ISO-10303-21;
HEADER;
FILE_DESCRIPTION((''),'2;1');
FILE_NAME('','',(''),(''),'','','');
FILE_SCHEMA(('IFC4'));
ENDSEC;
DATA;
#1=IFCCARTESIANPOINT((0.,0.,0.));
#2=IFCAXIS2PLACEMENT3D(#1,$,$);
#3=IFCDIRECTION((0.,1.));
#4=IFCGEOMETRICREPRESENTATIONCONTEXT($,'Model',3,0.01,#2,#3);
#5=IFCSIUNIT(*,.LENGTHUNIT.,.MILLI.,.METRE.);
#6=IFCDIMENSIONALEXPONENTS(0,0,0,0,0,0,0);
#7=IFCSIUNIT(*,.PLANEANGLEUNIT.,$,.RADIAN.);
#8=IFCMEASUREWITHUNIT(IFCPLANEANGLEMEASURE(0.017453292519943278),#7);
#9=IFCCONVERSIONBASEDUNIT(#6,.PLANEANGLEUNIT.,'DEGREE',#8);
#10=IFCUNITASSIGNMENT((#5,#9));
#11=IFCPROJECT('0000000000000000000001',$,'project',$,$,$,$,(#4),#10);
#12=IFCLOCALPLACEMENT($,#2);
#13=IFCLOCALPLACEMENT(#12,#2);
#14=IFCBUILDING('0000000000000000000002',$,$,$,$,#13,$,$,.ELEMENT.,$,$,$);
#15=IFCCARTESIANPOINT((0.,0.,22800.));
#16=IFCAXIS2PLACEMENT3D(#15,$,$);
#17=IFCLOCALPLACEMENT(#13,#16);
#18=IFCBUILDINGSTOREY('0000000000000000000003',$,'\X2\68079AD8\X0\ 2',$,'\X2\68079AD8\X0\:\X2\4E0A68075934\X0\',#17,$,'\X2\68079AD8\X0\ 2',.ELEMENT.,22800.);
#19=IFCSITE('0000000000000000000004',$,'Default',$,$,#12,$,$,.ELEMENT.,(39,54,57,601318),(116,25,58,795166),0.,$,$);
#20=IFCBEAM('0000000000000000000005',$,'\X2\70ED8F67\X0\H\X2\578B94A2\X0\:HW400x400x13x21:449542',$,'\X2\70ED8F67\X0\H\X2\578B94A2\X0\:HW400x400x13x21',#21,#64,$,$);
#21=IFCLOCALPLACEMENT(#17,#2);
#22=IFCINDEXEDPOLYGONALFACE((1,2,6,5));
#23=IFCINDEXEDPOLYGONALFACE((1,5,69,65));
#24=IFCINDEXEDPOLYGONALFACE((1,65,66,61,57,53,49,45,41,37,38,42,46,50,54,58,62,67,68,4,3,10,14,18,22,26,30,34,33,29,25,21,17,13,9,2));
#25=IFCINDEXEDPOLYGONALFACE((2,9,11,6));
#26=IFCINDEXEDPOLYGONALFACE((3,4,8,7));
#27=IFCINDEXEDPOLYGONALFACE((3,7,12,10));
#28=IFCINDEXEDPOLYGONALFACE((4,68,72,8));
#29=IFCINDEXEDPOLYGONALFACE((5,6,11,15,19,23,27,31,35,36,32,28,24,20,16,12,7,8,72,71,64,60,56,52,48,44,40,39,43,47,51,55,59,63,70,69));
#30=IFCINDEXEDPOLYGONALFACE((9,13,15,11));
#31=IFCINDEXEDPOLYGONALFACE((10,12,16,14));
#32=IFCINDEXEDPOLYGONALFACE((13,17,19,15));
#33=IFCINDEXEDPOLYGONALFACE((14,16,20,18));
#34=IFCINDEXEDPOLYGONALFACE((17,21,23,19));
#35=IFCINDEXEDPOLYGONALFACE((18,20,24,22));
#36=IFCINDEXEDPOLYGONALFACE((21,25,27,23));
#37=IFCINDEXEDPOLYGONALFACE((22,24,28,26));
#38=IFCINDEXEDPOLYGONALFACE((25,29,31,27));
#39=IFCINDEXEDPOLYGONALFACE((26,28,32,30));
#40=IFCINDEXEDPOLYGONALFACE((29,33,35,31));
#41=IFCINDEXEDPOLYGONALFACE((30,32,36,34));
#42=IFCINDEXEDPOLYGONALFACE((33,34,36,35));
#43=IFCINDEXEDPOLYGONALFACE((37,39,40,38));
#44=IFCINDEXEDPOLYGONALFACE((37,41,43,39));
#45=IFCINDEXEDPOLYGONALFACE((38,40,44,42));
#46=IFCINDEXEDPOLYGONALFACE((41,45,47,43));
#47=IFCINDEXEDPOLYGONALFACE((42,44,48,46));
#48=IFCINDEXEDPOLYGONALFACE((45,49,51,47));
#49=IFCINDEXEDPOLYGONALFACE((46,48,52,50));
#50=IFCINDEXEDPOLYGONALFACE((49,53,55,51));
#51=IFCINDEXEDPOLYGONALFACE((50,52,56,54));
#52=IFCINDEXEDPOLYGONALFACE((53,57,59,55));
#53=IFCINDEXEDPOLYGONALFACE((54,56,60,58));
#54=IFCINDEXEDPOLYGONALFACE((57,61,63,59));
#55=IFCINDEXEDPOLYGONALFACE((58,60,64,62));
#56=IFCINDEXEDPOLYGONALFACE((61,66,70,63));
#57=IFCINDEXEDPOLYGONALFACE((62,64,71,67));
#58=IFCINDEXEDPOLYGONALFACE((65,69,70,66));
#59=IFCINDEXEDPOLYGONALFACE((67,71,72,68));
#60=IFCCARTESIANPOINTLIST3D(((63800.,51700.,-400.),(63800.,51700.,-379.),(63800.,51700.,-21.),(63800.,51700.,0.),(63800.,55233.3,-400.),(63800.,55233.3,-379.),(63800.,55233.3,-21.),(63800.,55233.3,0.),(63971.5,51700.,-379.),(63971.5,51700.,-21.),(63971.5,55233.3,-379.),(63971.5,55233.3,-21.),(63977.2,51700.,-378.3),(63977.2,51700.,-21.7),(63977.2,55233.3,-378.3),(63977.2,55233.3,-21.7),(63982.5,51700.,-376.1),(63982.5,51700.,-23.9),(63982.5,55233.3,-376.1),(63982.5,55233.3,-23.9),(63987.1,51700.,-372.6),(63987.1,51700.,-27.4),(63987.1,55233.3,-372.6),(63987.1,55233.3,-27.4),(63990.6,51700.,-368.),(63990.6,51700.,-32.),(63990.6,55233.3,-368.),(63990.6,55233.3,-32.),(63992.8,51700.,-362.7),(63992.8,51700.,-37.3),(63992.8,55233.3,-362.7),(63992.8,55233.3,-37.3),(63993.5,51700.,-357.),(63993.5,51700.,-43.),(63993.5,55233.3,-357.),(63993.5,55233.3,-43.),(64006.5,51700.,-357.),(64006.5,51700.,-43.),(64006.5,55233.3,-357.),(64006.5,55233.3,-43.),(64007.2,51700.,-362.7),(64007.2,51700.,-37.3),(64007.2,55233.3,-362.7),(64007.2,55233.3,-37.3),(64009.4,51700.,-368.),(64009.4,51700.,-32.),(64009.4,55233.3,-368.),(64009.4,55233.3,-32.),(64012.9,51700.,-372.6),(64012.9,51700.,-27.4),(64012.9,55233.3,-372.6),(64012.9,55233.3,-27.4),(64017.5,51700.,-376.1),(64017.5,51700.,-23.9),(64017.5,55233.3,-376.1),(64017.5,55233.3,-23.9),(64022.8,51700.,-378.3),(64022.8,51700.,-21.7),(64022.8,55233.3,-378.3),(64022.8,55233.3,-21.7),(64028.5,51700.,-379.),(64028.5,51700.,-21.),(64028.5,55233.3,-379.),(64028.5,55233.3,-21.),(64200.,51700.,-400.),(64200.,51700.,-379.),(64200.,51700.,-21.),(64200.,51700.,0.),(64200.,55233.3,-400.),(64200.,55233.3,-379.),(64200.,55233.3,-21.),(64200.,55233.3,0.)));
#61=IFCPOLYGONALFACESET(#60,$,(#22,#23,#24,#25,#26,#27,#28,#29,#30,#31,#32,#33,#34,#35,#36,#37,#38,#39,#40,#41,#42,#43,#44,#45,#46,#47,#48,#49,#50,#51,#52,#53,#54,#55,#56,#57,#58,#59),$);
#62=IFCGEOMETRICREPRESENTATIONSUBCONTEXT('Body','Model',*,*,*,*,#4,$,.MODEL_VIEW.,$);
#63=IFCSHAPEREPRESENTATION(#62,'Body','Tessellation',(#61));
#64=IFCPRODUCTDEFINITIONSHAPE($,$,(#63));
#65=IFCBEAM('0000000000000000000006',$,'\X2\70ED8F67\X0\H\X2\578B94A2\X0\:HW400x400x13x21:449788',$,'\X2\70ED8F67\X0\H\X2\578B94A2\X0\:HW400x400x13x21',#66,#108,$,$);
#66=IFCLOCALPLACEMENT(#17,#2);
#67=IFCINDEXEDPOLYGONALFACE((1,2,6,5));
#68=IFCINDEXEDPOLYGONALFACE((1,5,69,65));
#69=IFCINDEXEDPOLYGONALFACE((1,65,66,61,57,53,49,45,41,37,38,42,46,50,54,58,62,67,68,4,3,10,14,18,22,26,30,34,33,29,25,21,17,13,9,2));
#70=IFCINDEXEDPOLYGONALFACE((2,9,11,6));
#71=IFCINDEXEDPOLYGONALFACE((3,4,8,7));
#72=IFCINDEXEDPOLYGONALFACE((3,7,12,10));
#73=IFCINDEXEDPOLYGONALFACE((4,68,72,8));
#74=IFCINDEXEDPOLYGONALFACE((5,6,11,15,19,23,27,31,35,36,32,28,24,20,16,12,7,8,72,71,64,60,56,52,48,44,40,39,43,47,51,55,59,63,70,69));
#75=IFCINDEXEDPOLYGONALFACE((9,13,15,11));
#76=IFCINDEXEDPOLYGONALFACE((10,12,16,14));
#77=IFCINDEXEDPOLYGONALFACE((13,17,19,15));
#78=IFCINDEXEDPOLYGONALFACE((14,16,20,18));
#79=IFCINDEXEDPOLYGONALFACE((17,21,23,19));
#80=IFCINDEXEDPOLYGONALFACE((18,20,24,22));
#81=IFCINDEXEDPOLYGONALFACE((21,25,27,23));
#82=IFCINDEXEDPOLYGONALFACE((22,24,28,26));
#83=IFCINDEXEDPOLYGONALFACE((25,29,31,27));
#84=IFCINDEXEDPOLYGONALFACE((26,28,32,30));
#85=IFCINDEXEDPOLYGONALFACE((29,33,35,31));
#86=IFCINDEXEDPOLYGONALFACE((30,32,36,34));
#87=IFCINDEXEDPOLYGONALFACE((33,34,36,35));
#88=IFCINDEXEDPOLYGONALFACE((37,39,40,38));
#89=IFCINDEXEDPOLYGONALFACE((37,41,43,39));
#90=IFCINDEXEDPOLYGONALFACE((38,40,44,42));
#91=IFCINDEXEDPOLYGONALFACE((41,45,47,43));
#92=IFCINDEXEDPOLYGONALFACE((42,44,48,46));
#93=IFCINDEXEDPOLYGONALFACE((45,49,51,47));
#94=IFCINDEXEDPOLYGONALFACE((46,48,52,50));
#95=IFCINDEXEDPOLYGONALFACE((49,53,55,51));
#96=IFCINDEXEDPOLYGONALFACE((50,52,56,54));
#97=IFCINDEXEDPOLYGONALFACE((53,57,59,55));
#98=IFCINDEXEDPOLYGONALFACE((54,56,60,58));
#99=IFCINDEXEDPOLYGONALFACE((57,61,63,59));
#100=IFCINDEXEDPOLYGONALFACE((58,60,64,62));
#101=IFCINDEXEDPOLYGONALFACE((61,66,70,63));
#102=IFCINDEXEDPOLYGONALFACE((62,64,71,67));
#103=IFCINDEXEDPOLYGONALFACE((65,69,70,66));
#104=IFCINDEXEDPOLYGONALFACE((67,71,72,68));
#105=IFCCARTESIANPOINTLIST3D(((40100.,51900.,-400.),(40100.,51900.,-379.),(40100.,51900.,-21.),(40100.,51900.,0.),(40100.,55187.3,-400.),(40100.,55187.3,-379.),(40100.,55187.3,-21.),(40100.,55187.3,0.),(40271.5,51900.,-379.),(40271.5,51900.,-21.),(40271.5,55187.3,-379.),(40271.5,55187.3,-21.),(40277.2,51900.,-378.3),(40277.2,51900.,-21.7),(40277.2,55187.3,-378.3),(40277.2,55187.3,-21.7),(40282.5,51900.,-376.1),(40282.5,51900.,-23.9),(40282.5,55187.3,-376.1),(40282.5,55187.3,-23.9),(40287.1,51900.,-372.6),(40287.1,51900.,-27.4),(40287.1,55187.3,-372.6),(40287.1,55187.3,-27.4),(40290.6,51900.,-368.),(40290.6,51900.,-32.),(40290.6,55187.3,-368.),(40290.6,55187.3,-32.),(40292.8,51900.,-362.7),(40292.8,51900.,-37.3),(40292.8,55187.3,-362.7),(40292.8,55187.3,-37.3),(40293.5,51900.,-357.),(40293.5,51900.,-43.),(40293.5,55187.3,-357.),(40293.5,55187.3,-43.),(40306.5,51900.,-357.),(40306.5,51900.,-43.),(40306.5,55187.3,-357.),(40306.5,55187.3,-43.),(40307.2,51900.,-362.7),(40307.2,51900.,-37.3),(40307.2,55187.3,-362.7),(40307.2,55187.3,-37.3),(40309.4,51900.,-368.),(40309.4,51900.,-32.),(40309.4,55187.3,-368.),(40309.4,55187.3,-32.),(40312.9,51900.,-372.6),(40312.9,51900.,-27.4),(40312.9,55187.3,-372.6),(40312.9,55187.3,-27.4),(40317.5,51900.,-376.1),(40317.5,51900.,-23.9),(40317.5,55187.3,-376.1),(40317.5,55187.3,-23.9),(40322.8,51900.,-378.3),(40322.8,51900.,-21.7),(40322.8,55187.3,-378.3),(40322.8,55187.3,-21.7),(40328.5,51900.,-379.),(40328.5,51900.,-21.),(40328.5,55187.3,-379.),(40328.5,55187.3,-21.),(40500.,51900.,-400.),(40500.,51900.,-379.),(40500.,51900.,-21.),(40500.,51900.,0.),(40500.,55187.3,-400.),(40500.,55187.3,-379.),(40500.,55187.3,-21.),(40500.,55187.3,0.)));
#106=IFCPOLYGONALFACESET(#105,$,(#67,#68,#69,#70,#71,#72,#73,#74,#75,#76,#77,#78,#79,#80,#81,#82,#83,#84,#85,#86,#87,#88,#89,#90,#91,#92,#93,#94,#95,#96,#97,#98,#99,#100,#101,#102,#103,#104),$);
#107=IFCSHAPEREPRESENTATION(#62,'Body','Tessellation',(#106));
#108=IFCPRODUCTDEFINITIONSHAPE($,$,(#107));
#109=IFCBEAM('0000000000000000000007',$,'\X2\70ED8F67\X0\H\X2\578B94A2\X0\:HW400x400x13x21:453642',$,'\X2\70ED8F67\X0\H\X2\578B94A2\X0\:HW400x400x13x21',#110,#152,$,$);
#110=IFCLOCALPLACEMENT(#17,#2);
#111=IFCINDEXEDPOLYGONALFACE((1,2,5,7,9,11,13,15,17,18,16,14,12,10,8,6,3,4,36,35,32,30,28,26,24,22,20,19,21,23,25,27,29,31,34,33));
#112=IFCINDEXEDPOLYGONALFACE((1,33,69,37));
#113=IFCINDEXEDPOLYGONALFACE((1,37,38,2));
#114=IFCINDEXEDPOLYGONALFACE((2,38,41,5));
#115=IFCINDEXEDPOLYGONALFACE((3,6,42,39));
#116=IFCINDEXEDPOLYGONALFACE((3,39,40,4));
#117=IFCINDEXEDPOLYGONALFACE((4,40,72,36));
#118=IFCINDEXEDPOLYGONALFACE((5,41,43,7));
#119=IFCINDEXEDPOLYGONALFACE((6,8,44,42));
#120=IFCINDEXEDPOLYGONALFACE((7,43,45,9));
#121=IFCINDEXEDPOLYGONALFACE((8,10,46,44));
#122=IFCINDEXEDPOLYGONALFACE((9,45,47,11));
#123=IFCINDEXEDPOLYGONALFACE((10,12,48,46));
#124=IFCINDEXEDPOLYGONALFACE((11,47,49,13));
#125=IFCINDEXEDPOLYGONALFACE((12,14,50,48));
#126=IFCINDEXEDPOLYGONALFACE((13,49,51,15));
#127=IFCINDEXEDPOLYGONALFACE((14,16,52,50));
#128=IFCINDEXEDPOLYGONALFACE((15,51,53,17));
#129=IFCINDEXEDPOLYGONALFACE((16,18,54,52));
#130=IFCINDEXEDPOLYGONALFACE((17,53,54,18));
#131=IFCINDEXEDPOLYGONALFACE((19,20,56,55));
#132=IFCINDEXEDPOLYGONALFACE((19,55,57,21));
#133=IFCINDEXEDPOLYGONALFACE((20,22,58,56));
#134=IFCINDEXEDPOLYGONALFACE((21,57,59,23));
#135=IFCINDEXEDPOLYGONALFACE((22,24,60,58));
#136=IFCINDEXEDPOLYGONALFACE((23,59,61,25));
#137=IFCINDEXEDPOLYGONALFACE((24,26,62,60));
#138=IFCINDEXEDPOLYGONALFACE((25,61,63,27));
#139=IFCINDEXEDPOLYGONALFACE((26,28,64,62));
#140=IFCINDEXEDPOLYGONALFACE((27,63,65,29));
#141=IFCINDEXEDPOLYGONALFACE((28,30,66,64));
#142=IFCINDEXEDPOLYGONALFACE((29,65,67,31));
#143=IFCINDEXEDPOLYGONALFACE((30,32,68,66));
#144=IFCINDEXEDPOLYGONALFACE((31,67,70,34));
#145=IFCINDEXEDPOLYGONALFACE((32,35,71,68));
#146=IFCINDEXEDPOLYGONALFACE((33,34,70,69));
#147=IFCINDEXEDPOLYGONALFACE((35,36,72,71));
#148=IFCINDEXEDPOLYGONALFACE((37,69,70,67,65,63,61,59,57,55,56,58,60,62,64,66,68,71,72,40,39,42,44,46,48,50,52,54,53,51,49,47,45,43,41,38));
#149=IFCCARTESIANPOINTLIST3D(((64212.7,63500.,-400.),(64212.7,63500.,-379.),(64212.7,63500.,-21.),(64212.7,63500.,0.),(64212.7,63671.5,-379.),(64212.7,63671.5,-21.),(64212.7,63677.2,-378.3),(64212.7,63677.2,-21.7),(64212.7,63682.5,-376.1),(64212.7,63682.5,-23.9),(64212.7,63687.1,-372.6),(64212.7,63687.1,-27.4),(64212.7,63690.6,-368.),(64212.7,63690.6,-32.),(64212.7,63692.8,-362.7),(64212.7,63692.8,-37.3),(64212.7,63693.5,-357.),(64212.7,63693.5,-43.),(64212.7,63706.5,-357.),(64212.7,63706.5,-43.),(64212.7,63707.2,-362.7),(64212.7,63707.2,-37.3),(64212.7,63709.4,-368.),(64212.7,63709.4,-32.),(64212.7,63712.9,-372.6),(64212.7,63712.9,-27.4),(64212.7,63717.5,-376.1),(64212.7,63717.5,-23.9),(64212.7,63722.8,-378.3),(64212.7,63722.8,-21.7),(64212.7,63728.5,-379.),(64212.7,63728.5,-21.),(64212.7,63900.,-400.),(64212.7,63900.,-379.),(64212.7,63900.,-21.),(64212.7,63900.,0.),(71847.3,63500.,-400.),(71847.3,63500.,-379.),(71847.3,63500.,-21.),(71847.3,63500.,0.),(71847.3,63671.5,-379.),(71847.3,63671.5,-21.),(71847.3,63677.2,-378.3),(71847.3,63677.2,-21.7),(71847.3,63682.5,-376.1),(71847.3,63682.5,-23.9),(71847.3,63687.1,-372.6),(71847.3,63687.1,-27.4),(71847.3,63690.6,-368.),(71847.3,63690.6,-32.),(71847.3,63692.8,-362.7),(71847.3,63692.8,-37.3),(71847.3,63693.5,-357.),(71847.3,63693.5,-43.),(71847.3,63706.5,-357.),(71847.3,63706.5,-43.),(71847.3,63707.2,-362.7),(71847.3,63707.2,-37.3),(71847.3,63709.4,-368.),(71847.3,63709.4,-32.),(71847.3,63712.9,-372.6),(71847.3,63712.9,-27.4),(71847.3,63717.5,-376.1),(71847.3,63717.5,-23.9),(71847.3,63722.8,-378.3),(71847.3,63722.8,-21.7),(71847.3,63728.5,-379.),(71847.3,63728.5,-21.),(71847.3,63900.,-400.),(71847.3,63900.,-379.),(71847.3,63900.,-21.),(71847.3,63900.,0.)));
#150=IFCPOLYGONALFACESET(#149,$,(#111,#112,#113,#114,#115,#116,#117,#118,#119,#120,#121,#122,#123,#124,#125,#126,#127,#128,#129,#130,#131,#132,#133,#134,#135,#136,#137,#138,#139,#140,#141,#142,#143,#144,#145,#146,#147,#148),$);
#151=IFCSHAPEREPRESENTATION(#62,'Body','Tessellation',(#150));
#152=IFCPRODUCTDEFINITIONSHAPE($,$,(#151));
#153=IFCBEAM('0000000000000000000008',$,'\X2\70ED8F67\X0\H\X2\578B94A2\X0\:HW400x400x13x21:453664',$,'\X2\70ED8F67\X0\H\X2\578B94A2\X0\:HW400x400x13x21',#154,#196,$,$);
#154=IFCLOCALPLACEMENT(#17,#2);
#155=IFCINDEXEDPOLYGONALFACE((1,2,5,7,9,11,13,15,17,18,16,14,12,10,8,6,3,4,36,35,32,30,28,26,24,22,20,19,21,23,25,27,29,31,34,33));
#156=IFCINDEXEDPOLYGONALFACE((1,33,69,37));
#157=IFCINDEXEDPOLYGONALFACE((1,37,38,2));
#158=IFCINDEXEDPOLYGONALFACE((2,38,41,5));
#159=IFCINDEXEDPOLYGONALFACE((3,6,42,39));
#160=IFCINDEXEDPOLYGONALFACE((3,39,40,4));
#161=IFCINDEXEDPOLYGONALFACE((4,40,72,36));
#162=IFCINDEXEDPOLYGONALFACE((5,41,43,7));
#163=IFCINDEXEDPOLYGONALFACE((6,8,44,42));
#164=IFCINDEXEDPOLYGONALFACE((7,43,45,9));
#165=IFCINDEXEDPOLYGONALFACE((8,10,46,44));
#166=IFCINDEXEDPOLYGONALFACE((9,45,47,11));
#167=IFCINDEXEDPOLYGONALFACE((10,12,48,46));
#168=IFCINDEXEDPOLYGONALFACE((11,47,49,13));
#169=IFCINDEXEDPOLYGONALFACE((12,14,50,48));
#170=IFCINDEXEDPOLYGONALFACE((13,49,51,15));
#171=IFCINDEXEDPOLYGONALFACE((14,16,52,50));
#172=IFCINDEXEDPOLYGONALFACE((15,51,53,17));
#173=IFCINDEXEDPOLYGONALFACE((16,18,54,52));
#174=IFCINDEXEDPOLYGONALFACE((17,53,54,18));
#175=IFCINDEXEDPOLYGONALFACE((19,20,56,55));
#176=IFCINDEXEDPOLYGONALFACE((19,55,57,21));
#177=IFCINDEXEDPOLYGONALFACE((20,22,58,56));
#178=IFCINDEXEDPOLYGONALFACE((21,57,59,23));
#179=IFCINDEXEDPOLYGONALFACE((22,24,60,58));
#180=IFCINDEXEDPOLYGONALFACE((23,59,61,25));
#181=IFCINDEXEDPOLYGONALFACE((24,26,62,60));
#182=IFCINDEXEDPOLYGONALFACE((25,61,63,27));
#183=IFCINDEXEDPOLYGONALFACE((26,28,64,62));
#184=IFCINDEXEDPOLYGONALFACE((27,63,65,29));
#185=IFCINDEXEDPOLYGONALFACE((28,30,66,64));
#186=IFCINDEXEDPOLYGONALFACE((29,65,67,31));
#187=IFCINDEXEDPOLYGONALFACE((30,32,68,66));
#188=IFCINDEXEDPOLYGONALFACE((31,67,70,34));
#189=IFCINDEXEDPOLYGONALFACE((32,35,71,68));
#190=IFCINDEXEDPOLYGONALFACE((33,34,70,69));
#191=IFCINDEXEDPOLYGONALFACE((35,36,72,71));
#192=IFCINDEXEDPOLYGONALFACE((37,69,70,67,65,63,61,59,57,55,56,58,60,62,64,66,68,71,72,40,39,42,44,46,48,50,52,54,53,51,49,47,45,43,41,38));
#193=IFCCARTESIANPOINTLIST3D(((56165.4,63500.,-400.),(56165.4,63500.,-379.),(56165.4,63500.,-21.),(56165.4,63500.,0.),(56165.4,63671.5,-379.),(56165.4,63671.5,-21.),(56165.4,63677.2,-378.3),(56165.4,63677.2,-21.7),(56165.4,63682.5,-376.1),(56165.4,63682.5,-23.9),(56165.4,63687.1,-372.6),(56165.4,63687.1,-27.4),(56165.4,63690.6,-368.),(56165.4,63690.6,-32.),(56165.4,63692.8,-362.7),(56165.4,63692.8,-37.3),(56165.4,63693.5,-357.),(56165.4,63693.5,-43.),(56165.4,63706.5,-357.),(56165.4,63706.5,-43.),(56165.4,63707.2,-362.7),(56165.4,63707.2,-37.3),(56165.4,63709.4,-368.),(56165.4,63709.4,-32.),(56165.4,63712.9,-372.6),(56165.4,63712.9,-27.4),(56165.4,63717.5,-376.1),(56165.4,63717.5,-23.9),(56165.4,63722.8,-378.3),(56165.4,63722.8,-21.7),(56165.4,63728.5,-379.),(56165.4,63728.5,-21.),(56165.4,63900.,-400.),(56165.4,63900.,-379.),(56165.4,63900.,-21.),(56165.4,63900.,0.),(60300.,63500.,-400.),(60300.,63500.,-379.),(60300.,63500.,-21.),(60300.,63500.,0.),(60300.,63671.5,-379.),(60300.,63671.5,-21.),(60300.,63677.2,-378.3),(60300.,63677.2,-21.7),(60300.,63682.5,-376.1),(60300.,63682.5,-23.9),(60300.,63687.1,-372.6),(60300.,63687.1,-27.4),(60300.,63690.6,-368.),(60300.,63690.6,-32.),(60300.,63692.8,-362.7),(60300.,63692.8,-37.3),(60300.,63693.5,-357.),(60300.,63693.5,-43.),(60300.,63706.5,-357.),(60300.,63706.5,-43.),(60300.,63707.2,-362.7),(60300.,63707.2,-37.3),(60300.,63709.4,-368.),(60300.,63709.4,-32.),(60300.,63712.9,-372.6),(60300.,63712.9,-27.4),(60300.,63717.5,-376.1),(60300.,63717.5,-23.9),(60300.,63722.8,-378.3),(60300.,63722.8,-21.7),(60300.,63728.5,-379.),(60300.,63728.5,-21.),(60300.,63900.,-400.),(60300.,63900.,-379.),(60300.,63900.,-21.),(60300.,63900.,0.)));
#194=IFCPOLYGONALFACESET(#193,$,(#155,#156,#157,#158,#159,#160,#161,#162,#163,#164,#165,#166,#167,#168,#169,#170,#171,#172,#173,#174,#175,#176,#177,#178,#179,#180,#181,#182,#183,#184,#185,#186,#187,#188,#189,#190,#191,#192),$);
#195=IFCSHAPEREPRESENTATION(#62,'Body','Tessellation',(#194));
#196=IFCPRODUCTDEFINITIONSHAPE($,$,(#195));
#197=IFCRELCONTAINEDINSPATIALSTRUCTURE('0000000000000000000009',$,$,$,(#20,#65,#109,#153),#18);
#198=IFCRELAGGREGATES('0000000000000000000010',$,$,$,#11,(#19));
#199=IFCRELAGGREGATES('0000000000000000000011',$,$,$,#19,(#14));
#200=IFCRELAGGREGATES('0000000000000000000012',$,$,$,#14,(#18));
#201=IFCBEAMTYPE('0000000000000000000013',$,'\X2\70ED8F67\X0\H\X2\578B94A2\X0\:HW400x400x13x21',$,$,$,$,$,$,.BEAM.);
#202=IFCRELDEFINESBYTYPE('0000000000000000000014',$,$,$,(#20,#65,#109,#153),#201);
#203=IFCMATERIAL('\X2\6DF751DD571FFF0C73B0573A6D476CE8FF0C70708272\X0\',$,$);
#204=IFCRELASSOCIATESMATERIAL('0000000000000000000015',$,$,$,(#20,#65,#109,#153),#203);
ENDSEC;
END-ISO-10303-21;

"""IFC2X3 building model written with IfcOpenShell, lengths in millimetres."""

from ifc_helpers import new_model, entity, si_unit, converted_unit, direction, frame, frame_2d, origin, place, context, subcontext, project, spatial, i_section, extrude, material, type_object, element, save


model = new_model("IFC2X3")

# Units and contexts
model_context = context("Model", 3, precision=0.01, world=origin(), true_north=direction((0.0, 1.0)))
body_context = subcontext(model_context, "Body", "Model", "MODEL_VIEW")
ifc_project = project(units=[si_unit("LENGTHUNIT", "METRE", prefix="MILLI"), converted_unit("PLANEANGLEUNIT", "DEGREE", entity("IfcPlaneAngleMeasure", 0.017453292519943278), si_unit("PLANEANGLEUNIT", "RADIAN"), dimensions=[0, 0, 0, 0, 0, 0, 0])], contexts=[model_context])

# Site, building, storey
site_placement = place(None, origin())
site = spatial("IfcSite", under=ifc_project, at=site_placement, Name="Default", CompositionType="ELEMENT", RefLatitude=(39, 54, 57, 601318), RefLongitude=(116, 25, 58, 795166), RefElevation=0.0)
building_placement = place(site_placement, origin())
building = spatial("IfcBuilding", under=site, at=building_placement, CompositionType="ELEMENT")
storey_placement = place(building_placement, frame((0.0, 0.0, 22800.0)))
storey = spatial("IfcBuildingStorey", under=building, at=storey_placement, Name="标高 2", ObjectType="标高:上标头", LongName="标高 2", CompositionType="ELEMENT", Elevation=22800.0)

# Beams
ifc_material = material(Name="混凝土，现场浇注，灰色")
beam_type = type_object("IfcBeamType", Name="热轧H型钢:HW400x400x13x21", PredefinedType="BEAM")
beam_1_placement = place(storey_placement, frame((64000.0, 55400.0, 0.0), z_axis=(0.0, 0.0, 1.0), x_axis=(0.0, -1.0, 0.0)))
element("IfcBeam", 1, at=beam_1_placement, inside=storey, type_object=beam_type, material=ifc_material, Name="热轧H型钢:HW400x400x13x21:449542", ObjectType="热轧H型钢:HW400x400x13x21", context=body_context, shape_type="SweptSolid", body=[
    extrude(i_section(OverallWidth=400.0, OverallDepth=400.0, WebThickness=13.0, FlangeThickness=21.0, FilletRadius=22.0, at=frame_2d((0.0, 0.0), x_axis=(0.0, 1.0))), frame((166.7, 0.0, -200.0), z_axis=(1.0, 0.0, 0.0), x_axis=(0.0, 0.0, -1.0)), (0.0, 0.0, 1.0), 3533.3),
])
beam_2_placement = place(storey_placement, frame((40300.0, 55400.0, 0.0), z_axis=(0.0, 0.0, 1.0), x_axis=(0.0, -1.0, 0.0)))
element("IfcBeam", 2, at=beam_2_placement, inside=storey, type_object=beam_type, material=ifc_material, Name="热轧H型钢:HW400x400x13x21:449788", ObjectType="热轧H型钢:HW400x400x13x21", context=body_context, shape_type="SweptSolid", body=[
    extrude(i_section(OverallWidth=400.0, OverallDepth=400.0, WebThickness=13.0, FlangeThickness=21.0, FilletRadius=22.0, at=frame_2d((0.0, 0.0), x_axis=(0.0, 1.0))), frame((212.7, 0.0, -200.0), z_axis=(1.0, 0.0, 0.0), x_axis=(0.0, 0.0, -1.0)), (0.0, 0.0, 1.0), 3287.3),
])
beam_3_placement = place(storey_placement, frame((72060.0, 63700.0, 0.0), z_axis=(0.0, 0.0, 1.0), x_axis=(-1.0, 0.0, 0.0)))
element("IfcBeam", 3, at=beam_3_placement, inside=storey, type_object=beam_type, material=ifc_material, Name="热轧H型钢:HW400x400x13x21:453642", ObjectType="热轧H型钢:HW400x400x13x21", context=body_context, shape_type="SweptSolid", body=[
    extrude(i_section(OverallWidth=400.0, OverallDepth=400.0, WebThickness=13.0, FlangeThickness=21.0, FilletRadius=22.0, at=frame_2d((0.0, 0.0), x_axis=(0.0, 1.0))), frame((212.7, 0.0, -200.0), z_axis=(1.0, 0.0, 0.0), x_axis=(0.0, 0.0, -1.0)), (0.0, 0.0, 1.0), 7634.6),
])
beam_4_placement = place(storey_placement, frame((60300.0, 63700.0, 0.0), z_axis=(0.0, 0.0, 1.0), x_axis=(-1.0, 0.0, 0.0)))
element("IfcBeam", 4, at=beam_4_placement, inside=storey, type_object=beam_type, material=ifc_material, Name="热轧H型钢:HW400x400x13x21:453664", ObjectType="热轧H型钢:HW400x400x13x21", context=body_context, shape_type="SweptSolid", body=[
    extrude(i_section(OverallWidth=400.0, OverallDepth=400.0, WebThickness=13.0, FlangeThickness=21.0, FilletRadius=22.0, at=frame_2d((0.0, 0.0), x_axis=(0.0, 1.0))), frame((0.0, 0.0, -200.0), z_axis=(1.0, 0.0, 0.0), x_axis=(0.0, 0.0, -1.0)), (0.0, 0.0, 1.0), 4134.6),
])

save(model, "model.ifc")
